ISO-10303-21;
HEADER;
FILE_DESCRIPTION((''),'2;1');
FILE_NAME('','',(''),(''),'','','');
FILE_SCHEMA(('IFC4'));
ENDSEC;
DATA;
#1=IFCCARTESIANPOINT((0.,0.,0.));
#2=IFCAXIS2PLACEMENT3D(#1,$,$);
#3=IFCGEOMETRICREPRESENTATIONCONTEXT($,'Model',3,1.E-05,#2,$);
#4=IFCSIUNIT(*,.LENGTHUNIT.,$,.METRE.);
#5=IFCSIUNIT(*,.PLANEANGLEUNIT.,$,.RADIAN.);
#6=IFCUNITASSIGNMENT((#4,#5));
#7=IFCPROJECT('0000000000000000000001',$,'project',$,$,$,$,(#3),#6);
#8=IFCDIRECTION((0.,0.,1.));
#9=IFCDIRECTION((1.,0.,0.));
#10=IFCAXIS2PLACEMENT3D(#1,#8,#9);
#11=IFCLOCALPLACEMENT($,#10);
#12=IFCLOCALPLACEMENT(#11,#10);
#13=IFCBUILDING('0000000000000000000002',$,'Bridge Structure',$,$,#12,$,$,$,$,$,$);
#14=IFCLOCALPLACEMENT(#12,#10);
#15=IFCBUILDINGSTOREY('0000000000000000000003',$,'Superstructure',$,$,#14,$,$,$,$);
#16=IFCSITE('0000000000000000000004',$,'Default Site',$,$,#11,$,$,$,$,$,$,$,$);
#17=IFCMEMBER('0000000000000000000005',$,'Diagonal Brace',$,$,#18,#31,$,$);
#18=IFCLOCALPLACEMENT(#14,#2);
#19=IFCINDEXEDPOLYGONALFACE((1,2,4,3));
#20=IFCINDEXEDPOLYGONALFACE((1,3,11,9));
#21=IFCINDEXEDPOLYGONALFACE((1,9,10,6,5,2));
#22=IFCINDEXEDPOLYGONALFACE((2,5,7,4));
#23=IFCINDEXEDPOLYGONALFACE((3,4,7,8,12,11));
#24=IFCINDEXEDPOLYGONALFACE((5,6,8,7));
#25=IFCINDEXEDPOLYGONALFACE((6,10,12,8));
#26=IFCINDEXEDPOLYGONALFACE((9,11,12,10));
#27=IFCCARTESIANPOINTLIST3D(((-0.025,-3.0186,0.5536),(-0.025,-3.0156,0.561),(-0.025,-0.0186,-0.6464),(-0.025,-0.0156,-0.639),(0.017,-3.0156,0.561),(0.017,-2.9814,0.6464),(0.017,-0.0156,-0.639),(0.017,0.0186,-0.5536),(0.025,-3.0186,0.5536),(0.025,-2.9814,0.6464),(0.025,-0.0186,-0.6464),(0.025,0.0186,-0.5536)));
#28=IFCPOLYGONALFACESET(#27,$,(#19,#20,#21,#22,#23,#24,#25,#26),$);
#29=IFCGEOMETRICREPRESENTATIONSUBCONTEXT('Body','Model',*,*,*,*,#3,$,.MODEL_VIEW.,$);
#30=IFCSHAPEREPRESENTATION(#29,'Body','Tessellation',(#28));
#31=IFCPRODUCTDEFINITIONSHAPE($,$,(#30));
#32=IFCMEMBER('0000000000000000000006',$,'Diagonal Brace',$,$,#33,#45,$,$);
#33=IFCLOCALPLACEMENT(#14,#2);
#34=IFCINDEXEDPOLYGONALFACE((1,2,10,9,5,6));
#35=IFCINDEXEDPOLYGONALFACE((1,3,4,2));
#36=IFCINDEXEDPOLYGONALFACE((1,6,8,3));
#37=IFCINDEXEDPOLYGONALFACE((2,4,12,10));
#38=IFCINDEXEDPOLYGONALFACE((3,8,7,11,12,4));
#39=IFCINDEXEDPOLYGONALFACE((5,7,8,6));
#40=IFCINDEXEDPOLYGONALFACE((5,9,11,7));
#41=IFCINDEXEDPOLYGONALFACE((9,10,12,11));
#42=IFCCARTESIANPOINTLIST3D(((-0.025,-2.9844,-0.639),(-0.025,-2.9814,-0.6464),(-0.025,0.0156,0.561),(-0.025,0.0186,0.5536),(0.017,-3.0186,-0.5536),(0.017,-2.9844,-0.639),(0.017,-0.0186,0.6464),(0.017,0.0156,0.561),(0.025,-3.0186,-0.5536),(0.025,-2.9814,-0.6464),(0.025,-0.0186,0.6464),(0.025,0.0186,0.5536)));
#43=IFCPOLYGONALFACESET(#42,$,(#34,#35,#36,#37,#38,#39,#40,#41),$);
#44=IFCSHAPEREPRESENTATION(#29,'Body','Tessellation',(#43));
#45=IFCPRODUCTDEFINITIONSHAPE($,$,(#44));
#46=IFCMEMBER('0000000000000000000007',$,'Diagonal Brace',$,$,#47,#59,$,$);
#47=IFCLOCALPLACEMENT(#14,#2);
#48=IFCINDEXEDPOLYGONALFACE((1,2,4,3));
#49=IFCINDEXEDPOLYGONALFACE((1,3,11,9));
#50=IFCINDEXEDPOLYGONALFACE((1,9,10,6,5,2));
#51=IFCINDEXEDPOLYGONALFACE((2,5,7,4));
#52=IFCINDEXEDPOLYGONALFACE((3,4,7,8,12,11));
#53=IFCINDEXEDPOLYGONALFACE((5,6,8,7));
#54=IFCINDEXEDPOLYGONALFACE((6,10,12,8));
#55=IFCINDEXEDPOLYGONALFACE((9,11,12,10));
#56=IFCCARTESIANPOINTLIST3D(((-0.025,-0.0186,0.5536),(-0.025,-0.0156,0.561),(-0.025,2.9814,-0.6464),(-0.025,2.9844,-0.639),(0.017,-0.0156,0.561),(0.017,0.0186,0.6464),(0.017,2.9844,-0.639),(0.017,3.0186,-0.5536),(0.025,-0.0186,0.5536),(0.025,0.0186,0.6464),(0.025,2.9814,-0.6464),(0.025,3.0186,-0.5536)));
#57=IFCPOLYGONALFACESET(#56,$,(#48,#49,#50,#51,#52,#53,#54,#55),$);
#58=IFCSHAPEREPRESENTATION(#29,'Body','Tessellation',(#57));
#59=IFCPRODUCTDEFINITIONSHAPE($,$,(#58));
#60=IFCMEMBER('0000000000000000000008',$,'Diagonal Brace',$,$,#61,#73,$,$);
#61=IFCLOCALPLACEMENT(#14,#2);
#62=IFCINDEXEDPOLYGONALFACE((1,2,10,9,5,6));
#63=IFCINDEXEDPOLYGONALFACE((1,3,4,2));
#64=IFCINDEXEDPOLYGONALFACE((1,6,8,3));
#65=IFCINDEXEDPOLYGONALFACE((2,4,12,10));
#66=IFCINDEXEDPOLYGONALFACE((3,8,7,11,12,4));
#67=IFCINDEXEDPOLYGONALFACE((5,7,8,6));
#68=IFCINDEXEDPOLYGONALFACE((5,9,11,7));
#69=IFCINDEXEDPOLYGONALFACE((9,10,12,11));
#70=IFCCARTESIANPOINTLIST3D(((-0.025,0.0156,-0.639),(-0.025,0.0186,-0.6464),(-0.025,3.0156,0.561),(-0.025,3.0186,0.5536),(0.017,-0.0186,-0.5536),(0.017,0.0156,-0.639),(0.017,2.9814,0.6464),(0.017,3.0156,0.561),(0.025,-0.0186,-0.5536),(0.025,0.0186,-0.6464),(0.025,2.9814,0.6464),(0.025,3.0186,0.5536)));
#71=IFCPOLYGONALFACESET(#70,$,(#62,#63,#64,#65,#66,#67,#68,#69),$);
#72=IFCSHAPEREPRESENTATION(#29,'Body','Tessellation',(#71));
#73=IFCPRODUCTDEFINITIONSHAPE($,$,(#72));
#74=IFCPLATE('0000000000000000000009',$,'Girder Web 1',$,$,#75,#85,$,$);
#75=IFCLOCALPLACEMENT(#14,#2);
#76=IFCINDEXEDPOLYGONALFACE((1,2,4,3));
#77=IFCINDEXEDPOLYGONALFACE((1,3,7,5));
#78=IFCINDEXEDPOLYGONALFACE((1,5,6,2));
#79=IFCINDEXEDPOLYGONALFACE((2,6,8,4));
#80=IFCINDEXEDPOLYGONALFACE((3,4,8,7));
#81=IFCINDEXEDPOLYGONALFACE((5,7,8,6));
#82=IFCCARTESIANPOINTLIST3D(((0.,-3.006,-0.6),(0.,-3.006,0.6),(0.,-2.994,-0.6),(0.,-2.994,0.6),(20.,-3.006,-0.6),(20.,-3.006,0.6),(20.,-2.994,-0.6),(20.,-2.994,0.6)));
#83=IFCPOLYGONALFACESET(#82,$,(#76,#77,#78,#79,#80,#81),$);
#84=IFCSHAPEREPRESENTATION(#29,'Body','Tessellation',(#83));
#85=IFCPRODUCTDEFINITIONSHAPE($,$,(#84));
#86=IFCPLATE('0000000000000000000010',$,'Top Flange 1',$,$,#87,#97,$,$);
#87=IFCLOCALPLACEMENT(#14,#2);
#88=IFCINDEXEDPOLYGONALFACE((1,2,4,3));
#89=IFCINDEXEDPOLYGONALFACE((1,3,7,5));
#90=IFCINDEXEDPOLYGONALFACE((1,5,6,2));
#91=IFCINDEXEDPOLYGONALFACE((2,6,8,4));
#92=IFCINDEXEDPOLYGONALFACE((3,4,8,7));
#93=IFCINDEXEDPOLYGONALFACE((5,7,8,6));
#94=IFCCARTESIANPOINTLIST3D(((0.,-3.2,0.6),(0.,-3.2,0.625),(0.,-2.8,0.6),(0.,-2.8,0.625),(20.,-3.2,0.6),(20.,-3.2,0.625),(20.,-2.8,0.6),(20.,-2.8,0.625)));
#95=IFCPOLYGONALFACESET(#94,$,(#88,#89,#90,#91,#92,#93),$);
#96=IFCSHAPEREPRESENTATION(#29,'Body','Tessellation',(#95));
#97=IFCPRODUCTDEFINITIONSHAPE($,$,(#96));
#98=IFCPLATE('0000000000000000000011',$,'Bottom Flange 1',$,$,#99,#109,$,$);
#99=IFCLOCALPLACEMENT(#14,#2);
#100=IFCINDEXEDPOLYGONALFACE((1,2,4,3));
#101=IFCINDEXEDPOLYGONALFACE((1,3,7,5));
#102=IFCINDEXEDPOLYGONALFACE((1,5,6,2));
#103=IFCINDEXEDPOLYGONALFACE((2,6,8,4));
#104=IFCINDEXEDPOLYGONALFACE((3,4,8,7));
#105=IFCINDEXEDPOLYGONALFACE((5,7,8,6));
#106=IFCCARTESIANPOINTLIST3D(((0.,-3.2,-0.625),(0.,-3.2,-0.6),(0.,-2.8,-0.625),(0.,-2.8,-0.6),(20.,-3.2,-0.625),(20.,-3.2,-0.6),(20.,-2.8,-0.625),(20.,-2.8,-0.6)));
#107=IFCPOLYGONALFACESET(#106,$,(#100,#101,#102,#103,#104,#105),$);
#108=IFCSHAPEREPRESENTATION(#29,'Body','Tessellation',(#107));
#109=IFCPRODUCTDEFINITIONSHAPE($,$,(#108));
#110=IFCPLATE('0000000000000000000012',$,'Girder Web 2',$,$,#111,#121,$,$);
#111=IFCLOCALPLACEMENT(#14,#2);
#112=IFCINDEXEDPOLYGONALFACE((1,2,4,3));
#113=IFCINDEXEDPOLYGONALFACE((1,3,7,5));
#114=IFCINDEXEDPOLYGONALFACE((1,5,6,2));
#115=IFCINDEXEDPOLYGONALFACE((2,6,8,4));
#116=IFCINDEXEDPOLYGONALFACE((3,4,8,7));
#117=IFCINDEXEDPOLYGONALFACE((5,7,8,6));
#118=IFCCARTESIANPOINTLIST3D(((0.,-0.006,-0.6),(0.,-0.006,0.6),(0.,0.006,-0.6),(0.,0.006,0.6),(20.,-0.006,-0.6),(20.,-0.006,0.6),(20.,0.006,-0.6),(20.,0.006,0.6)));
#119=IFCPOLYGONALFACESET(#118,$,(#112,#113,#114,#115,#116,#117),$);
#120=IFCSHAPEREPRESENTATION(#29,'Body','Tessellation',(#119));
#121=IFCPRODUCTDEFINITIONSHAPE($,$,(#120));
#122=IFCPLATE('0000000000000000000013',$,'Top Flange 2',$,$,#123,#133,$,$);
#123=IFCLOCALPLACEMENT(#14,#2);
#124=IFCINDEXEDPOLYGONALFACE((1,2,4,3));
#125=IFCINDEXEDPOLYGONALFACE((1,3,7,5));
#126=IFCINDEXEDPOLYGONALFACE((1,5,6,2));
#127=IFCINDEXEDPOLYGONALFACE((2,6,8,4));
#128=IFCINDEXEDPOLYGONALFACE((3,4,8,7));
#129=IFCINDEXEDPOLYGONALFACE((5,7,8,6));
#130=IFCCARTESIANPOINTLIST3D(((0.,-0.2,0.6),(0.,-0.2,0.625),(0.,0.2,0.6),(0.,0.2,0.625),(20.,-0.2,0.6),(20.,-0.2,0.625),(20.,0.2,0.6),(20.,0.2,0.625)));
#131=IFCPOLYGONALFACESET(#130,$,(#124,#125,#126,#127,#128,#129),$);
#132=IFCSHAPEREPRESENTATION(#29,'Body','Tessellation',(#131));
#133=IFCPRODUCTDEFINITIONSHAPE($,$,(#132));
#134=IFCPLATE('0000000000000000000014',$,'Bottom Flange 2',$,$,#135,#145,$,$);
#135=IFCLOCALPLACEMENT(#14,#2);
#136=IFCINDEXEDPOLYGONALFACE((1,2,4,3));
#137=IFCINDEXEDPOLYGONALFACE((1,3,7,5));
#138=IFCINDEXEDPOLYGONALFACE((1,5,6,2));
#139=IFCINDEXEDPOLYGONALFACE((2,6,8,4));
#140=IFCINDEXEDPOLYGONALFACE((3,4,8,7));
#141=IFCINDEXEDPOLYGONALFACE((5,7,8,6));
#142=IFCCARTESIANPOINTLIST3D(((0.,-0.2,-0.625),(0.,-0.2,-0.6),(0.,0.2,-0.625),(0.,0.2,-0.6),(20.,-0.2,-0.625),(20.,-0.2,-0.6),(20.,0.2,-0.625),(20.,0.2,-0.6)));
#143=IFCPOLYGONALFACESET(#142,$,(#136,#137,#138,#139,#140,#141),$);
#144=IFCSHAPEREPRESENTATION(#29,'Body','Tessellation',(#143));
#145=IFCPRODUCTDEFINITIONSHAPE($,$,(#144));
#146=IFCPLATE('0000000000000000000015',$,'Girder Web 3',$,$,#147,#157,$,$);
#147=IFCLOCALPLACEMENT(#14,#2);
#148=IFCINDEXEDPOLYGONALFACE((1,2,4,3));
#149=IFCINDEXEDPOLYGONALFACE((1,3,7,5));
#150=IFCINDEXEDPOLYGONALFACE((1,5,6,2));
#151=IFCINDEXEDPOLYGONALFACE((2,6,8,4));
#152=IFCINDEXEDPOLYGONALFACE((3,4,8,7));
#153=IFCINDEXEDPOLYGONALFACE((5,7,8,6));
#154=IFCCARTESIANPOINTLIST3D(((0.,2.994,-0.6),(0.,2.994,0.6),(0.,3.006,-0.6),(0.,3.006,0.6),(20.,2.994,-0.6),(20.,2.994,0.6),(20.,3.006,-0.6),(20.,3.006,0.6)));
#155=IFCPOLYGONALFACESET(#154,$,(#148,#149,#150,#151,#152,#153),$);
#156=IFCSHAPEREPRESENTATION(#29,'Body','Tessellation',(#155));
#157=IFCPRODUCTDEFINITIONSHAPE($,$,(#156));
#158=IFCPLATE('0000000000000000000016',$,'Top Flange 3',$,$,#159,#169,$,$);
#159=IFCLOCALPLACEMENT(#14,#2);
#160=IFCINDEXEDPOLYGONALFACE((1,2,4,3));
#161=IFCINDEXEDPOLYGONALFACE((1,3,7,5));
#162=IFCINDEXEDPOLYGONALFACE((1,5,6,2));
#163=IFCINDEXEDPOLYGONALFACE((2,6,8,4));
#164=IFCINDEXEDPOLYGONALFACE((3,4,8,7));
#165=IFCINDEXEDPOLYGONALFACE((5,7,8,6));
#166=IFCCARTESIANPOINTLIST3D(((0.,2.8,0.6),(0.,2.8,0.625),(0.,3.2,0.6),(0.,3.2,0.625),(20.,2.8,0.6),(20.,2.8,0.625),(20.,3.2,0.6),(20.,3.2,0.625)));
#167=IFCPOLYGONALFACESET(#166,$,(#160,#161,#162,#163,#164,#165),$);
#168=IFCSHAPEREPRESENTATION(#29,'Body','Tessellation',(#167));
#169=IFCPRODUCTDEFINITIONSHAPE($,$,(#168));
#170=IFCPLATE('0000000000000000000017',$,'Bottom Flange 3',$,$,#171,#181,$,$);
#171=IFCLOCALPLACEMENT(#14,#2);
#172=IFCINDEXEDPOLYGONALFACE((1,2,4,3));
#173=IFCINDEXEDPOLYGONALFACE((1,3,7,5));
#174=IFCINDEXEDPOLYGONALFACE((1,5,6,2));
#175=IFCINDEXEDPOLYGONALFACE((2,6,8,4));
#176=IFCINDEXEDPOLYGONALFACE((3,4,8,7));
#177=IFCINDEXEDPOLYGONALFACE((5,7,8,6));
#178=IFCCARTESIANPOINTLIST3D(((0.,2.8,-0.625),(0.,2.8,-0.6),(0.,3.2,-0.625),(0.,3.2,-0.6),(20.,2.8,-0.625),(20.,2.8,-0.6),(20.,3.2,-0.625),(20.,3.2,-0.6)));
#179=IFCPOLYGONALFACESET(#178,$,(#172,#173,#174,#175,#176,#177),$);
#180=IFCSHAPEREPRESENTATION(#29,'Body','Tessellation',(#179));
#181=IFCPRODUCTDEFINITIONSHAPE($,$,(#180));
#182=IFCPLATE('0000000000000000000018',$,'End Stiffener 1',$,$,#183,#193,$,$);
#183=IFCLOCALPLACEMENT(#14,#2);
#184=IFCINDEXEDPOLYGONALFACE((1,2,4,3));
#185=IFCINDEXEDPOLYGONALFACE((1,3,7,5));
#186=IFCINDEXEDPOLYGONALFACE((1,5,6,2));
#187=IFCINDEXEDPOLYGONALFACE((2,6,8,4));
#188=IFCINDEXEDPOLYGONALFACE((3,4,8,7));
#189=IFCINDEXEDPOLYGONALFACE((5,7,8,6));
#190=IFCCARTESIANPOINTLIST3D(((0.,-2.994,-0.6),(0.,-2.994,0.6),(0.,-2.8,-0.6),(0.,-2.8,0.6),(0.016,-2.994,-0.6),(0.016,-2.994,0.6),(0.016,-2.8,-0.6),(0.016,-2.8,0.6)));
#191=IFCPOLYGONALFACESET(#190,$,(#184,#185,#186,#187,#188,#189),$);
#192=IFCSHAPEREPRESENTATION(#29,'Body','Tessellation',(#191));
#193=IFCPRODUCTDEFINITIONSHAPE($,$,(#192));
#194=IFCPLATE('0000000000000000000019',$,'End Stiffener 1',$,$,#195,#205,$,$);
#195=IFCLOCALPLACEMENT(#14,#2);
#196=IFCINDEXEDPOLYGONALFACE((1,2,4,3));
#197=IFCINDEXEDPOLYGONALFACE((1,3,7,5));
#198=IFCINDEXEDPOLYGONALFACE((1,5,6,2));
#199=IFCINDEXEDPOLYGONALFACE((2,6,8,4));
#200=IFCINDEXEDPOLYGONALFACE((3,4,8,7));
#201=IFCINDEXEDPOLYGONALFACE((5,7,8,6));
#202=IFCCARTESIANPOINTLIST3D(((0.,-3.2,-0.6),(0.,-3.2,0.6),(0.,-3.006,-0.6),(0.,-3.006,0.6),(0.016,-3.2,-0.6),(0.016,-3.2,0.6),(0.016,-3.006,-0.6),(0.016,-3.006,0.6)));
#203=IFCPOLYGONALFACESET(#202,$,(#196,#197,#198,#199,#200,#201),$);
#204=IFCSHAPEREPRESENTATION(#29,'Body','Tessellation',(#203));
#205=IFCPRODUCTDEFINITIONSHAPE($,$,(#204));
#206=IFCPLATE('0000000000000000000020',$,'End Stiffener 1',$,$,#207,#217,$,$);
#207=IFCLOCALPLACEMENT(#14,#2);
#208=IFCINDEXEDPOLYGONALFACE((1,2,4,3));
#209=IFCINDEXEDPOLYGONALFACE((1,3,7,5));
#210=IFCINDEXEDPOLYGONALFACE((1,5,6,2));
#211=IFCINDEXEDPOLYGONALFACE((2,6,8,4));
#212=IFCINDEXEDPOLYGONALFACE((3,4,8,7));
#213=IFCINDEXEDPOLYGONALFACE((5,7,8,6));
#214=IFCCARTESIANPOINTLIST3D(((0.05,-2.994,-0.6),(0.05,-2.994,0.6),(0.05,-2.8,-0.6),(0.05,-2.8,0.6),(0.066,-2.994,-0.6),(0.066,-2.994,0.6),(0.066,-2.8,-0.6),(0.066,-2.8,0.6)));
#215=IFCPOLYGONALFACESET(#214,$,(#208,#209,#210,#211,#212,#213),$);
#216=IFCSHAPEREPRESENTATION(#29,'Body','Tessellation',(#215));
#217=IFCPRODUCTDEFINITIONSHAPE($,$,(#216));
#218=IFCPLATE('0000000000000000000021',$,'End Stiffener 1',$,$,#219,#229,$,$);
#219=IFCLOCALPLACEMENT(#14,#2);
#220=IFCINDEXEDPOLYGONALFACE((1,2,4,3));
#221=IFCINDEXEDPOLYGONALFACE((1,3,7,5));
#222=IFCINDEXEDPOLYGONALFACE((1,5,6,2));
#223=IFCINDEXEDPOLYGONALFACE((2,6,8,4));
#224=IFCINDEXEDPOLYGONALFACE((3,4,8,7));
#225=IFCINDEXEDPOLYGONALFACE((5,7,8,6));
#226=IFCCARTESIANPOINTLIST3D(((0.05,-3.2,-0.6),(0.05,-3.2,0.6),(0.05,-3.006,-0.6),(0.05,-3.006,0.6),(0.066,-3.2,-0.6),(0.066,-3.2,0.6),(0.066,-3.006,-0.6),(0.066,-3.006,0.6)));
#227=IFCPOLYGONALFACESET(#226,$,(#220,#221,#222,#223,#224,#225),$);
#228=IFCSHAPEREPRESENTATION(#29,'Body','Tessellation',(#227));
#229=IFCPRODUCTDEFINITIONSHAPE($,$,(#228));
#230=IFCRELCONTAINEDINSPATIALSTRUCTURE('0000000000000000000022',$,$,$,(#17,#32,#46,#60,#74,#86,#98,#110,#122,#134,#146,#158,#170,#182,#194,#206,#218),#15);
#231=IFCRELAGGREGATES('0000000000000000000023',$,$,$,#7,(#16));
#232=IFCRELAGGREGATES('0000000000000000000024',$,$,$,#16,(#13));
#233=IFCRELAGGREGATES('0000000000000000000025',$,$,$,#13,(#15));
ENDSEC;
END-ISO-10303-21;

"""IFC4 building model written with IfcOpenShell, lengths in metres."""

from ifc_helpers import new_model, si_unit, frame, origin, origin_with_axes, origin_2d_with_axis, place, context, subcontext, project, spatial, rectangle, l_section, extrude, element, save


model = new_model("IFC4")

# Units and contexts
model_context = context("Model", 3, precision=1e-05, world=origin())
body_context = subcontext(model_context, "Body", "Model", "MODEL_VIEW")
ifc_project = project(units=[si_unit("LENGTHUNIT", "METRE"), si_unit("PLANEANGLEUNIT", "RADIAN")], contexts=[model_context])

# Site, building, storey
site_placement = place(None, origin_with_axes())
site = spatial("IfcSite", under=ifc_project, at=site_placement, Name="Default Site")
building_placement = place(site_placement, origin_with_axes())
building = spatial("IfcBuilding", under=site, at=building_placement, Name="Bridge Structure")
storey_placement = place(building_placement, origin_with_axes())
storey = spatial("IfcBuildingStorey", under=building, at=storey_placement, Name="Superstructure")

# Members
for number, where, z_axis, x_axis, name in (
    (1, (0.0, -3.0, 0.6), (0.0, 0.928477, -0.371391), (-1.0, 0.0, 0.0), "Diagonal Brace"),
    (2, (0.0, -3.0, -0.6), (0.0, 0.928477, 0.371391), (-1.0, 0.0, 0.0), "Diagonal Brace"),
    (3, (0.0, 0.0, 0.6), (0.0, 0.928477, -0.371391), (-1.0, 0.0, 0.0), "Diagonal Brace"),
    (4, (0.0, 0.0, -0.6), (0.0, 0.928477, 0.371391), (-1.0, 0.0, 0.0), "Diagonal Brace"),
):
    element("IfcMember", number, at=place(storey_placement, frame(where, z_axis=z_axis, x_axis=x_axis)), inside=storey, Name=name, context=body_context, shape_type="SweptSolid", body=[
        extrude(l_section(Depth=0.1, Width=0.05, Thickness=0.008, at=origin_2d_with_axis()), origin_with_axes(), (0.0, 0.0, 1.0), 3.2311),
    ])

# Plates
plate_1_placement = place(storey_placement, frame((0.0, -3.0, 0.0), z_axis=(1.0, 0.0, 0.0), x_axis=(0.0, 1.0, 0.0)))
element("IfcPlate", 5, at=plate_1_placement, inside=storey, Name="Girder Web 1", context=body_context, shape_type="SweptSolid", body=[
    extrude(rectangle(XDim=0.012, YDim=1.2, at=origin_2d_with_axis()), origin_with_axes(), (0.0, 0.0, 1.0), 20.0),
])
for number, where, z_axis, x_axis, name in (
    (6, (0.0, -3.0, 0.6125), (1.0, 0.0, 0.0), (0.0, 1.0, 0.0), "Top Flange 1"),
    (7, (0.0, -3.0, -0.6125), (1.0, 0.0, 0.0), (0.0, 1.0, 0.0), "Bottom Flange 1"),
):
    element("IfcPlate", number, at=place(storey_placement, frame(where, z_axis=z_axis, x_axis=x_axis)), inside=storey, Name=name, context=body_context, shape_type="SweptSolid", body=[
        extrude(rectangle(XDim=0.4, YDim=0.025, at=origin_2d_with_axis()), origin_with_axes(), (0.0, 0.0, 1.0), 20.0),
    ])
plate_2_placement = place(storey_placement, frame((0.0, 0.0, 0.0), z_axis=(1.0, 0.0, 0.0), x_axis=(0.0, 1.0, 0.0)))
element("IfcPlate", 8, at=plate_2_placement, inside=storey, Name="Girder Web 2", context=body_context, shape_type="SweptSolid", body=[
    extrude(rectangle(XDim=0.012, YDim=1.2, at=origin_2d_with_axis()), origin_with_axes(), (0.0, 0.0, 1.0), 20.0),
])
for number, where, z_axis, x_axis, name in (
    (9, (0.0, 0.0, 0.6125), (1.0, 0.0, 0.0), (0.0, 1.0, 0.0), "Top Flange 2"),
    (10, (0.0, 0.0, -0.6125), (1.0, 0.0, 0.0), (0.0, 1.0, 0.0), "Bottom Flange 2"),
):
    element("IfcPlate", number, at=place(storey_placement, frame(where, z_axis=z_axis, x_axis=x_axis)), inside=storey, Name=name, context=body_context, shape_type="SweptSolid", body=[
        extrude(rectangle(XDim=0.4, YDim=0.025, at=origin_2d_with_axis()), origin_with_axes(), (0.0, 0.0, 1.0), 20.0),
    ])
plate_3_placement = place(storey_placement, frame((0.0, 3.0, 0.0), z_axis=(1.0, 0.0, 0.0), x_axis=(0.0, 1.0, 0.0)))
element("IfcPlate", 11, at=plate_3_placement, inside=storey, Name="Girder Web 3", context=body_context, shape_type="SweptSolid", body=[
    extrude(rectangle(XDim=0.012, YDim=1.2, at=origin_2d_with_axis()), origin_with_axes(), (0.0, 0.0, 1.0), 20.0),
])
for number, where, z_axis, x_axis, name in (
    (12, (0.0, 3.0, 0.6125), (1.0, 0.0, 0.0), (0.0, 1.0, 0.0), "Top Flange 3"),
    (13, (0.0, 3.0, -0.6125), (1.0, 0.0, 0.0), (0.0, 1.0, 0.0), "Bottom Flange 3"),
):
    element("IfcPlate", number, at=place(storey_placement, frame(where, z_axis=z_axis, x_axis=x_axis)), inside=storey, Name=name, context=body_context, shape_type="SweptSolid", body=[
        extrude(rectangle(XDim=0.4, YDim=0.025, at=origin_2d_with_axis()), origin_with_axes(), (0.0, 0.0, 1.0), 20.0),
    ])
for number, where, z_axis, x_axis, name in (
    (14, (0.008, -2.897, -0.6), (0.0, 0.0, 1.0), (1.0, 0.0, 0.0), "End Stiffener 1"),
    (15, (0.008, -3.103, -0.6), (0.0, 0.0, 1.0), (1.0, 0.0, 0.0), "End Stiffener 1"),
    (16, (0.058, -2.897, -0.6), (0.0, 0.0, 1.0), (1.0, 0.0, 0.0), "End Stiffener 1"),
    (17, (0.058, -3.103, -0.6), (0.0, 0.0, 1.0), (1.0, 0.0, 0.0), "End Stiffener 1"),
):
    element("IfcPlate", number, at=place(storey_placement, frame(where, z_axis=z_axis, x_axis=x_axis)), inside=storey, Name=name, context=body_context, shape_type="SweptSolid", body=[
        extrude(rectangle(XDim=0.016, YDim=0.194, at=origin_2d_with_axis()), origin_with_axes(), (0.0, 0.0, 1.0), 1.2),
    ])

save(model, "model.ifc")
